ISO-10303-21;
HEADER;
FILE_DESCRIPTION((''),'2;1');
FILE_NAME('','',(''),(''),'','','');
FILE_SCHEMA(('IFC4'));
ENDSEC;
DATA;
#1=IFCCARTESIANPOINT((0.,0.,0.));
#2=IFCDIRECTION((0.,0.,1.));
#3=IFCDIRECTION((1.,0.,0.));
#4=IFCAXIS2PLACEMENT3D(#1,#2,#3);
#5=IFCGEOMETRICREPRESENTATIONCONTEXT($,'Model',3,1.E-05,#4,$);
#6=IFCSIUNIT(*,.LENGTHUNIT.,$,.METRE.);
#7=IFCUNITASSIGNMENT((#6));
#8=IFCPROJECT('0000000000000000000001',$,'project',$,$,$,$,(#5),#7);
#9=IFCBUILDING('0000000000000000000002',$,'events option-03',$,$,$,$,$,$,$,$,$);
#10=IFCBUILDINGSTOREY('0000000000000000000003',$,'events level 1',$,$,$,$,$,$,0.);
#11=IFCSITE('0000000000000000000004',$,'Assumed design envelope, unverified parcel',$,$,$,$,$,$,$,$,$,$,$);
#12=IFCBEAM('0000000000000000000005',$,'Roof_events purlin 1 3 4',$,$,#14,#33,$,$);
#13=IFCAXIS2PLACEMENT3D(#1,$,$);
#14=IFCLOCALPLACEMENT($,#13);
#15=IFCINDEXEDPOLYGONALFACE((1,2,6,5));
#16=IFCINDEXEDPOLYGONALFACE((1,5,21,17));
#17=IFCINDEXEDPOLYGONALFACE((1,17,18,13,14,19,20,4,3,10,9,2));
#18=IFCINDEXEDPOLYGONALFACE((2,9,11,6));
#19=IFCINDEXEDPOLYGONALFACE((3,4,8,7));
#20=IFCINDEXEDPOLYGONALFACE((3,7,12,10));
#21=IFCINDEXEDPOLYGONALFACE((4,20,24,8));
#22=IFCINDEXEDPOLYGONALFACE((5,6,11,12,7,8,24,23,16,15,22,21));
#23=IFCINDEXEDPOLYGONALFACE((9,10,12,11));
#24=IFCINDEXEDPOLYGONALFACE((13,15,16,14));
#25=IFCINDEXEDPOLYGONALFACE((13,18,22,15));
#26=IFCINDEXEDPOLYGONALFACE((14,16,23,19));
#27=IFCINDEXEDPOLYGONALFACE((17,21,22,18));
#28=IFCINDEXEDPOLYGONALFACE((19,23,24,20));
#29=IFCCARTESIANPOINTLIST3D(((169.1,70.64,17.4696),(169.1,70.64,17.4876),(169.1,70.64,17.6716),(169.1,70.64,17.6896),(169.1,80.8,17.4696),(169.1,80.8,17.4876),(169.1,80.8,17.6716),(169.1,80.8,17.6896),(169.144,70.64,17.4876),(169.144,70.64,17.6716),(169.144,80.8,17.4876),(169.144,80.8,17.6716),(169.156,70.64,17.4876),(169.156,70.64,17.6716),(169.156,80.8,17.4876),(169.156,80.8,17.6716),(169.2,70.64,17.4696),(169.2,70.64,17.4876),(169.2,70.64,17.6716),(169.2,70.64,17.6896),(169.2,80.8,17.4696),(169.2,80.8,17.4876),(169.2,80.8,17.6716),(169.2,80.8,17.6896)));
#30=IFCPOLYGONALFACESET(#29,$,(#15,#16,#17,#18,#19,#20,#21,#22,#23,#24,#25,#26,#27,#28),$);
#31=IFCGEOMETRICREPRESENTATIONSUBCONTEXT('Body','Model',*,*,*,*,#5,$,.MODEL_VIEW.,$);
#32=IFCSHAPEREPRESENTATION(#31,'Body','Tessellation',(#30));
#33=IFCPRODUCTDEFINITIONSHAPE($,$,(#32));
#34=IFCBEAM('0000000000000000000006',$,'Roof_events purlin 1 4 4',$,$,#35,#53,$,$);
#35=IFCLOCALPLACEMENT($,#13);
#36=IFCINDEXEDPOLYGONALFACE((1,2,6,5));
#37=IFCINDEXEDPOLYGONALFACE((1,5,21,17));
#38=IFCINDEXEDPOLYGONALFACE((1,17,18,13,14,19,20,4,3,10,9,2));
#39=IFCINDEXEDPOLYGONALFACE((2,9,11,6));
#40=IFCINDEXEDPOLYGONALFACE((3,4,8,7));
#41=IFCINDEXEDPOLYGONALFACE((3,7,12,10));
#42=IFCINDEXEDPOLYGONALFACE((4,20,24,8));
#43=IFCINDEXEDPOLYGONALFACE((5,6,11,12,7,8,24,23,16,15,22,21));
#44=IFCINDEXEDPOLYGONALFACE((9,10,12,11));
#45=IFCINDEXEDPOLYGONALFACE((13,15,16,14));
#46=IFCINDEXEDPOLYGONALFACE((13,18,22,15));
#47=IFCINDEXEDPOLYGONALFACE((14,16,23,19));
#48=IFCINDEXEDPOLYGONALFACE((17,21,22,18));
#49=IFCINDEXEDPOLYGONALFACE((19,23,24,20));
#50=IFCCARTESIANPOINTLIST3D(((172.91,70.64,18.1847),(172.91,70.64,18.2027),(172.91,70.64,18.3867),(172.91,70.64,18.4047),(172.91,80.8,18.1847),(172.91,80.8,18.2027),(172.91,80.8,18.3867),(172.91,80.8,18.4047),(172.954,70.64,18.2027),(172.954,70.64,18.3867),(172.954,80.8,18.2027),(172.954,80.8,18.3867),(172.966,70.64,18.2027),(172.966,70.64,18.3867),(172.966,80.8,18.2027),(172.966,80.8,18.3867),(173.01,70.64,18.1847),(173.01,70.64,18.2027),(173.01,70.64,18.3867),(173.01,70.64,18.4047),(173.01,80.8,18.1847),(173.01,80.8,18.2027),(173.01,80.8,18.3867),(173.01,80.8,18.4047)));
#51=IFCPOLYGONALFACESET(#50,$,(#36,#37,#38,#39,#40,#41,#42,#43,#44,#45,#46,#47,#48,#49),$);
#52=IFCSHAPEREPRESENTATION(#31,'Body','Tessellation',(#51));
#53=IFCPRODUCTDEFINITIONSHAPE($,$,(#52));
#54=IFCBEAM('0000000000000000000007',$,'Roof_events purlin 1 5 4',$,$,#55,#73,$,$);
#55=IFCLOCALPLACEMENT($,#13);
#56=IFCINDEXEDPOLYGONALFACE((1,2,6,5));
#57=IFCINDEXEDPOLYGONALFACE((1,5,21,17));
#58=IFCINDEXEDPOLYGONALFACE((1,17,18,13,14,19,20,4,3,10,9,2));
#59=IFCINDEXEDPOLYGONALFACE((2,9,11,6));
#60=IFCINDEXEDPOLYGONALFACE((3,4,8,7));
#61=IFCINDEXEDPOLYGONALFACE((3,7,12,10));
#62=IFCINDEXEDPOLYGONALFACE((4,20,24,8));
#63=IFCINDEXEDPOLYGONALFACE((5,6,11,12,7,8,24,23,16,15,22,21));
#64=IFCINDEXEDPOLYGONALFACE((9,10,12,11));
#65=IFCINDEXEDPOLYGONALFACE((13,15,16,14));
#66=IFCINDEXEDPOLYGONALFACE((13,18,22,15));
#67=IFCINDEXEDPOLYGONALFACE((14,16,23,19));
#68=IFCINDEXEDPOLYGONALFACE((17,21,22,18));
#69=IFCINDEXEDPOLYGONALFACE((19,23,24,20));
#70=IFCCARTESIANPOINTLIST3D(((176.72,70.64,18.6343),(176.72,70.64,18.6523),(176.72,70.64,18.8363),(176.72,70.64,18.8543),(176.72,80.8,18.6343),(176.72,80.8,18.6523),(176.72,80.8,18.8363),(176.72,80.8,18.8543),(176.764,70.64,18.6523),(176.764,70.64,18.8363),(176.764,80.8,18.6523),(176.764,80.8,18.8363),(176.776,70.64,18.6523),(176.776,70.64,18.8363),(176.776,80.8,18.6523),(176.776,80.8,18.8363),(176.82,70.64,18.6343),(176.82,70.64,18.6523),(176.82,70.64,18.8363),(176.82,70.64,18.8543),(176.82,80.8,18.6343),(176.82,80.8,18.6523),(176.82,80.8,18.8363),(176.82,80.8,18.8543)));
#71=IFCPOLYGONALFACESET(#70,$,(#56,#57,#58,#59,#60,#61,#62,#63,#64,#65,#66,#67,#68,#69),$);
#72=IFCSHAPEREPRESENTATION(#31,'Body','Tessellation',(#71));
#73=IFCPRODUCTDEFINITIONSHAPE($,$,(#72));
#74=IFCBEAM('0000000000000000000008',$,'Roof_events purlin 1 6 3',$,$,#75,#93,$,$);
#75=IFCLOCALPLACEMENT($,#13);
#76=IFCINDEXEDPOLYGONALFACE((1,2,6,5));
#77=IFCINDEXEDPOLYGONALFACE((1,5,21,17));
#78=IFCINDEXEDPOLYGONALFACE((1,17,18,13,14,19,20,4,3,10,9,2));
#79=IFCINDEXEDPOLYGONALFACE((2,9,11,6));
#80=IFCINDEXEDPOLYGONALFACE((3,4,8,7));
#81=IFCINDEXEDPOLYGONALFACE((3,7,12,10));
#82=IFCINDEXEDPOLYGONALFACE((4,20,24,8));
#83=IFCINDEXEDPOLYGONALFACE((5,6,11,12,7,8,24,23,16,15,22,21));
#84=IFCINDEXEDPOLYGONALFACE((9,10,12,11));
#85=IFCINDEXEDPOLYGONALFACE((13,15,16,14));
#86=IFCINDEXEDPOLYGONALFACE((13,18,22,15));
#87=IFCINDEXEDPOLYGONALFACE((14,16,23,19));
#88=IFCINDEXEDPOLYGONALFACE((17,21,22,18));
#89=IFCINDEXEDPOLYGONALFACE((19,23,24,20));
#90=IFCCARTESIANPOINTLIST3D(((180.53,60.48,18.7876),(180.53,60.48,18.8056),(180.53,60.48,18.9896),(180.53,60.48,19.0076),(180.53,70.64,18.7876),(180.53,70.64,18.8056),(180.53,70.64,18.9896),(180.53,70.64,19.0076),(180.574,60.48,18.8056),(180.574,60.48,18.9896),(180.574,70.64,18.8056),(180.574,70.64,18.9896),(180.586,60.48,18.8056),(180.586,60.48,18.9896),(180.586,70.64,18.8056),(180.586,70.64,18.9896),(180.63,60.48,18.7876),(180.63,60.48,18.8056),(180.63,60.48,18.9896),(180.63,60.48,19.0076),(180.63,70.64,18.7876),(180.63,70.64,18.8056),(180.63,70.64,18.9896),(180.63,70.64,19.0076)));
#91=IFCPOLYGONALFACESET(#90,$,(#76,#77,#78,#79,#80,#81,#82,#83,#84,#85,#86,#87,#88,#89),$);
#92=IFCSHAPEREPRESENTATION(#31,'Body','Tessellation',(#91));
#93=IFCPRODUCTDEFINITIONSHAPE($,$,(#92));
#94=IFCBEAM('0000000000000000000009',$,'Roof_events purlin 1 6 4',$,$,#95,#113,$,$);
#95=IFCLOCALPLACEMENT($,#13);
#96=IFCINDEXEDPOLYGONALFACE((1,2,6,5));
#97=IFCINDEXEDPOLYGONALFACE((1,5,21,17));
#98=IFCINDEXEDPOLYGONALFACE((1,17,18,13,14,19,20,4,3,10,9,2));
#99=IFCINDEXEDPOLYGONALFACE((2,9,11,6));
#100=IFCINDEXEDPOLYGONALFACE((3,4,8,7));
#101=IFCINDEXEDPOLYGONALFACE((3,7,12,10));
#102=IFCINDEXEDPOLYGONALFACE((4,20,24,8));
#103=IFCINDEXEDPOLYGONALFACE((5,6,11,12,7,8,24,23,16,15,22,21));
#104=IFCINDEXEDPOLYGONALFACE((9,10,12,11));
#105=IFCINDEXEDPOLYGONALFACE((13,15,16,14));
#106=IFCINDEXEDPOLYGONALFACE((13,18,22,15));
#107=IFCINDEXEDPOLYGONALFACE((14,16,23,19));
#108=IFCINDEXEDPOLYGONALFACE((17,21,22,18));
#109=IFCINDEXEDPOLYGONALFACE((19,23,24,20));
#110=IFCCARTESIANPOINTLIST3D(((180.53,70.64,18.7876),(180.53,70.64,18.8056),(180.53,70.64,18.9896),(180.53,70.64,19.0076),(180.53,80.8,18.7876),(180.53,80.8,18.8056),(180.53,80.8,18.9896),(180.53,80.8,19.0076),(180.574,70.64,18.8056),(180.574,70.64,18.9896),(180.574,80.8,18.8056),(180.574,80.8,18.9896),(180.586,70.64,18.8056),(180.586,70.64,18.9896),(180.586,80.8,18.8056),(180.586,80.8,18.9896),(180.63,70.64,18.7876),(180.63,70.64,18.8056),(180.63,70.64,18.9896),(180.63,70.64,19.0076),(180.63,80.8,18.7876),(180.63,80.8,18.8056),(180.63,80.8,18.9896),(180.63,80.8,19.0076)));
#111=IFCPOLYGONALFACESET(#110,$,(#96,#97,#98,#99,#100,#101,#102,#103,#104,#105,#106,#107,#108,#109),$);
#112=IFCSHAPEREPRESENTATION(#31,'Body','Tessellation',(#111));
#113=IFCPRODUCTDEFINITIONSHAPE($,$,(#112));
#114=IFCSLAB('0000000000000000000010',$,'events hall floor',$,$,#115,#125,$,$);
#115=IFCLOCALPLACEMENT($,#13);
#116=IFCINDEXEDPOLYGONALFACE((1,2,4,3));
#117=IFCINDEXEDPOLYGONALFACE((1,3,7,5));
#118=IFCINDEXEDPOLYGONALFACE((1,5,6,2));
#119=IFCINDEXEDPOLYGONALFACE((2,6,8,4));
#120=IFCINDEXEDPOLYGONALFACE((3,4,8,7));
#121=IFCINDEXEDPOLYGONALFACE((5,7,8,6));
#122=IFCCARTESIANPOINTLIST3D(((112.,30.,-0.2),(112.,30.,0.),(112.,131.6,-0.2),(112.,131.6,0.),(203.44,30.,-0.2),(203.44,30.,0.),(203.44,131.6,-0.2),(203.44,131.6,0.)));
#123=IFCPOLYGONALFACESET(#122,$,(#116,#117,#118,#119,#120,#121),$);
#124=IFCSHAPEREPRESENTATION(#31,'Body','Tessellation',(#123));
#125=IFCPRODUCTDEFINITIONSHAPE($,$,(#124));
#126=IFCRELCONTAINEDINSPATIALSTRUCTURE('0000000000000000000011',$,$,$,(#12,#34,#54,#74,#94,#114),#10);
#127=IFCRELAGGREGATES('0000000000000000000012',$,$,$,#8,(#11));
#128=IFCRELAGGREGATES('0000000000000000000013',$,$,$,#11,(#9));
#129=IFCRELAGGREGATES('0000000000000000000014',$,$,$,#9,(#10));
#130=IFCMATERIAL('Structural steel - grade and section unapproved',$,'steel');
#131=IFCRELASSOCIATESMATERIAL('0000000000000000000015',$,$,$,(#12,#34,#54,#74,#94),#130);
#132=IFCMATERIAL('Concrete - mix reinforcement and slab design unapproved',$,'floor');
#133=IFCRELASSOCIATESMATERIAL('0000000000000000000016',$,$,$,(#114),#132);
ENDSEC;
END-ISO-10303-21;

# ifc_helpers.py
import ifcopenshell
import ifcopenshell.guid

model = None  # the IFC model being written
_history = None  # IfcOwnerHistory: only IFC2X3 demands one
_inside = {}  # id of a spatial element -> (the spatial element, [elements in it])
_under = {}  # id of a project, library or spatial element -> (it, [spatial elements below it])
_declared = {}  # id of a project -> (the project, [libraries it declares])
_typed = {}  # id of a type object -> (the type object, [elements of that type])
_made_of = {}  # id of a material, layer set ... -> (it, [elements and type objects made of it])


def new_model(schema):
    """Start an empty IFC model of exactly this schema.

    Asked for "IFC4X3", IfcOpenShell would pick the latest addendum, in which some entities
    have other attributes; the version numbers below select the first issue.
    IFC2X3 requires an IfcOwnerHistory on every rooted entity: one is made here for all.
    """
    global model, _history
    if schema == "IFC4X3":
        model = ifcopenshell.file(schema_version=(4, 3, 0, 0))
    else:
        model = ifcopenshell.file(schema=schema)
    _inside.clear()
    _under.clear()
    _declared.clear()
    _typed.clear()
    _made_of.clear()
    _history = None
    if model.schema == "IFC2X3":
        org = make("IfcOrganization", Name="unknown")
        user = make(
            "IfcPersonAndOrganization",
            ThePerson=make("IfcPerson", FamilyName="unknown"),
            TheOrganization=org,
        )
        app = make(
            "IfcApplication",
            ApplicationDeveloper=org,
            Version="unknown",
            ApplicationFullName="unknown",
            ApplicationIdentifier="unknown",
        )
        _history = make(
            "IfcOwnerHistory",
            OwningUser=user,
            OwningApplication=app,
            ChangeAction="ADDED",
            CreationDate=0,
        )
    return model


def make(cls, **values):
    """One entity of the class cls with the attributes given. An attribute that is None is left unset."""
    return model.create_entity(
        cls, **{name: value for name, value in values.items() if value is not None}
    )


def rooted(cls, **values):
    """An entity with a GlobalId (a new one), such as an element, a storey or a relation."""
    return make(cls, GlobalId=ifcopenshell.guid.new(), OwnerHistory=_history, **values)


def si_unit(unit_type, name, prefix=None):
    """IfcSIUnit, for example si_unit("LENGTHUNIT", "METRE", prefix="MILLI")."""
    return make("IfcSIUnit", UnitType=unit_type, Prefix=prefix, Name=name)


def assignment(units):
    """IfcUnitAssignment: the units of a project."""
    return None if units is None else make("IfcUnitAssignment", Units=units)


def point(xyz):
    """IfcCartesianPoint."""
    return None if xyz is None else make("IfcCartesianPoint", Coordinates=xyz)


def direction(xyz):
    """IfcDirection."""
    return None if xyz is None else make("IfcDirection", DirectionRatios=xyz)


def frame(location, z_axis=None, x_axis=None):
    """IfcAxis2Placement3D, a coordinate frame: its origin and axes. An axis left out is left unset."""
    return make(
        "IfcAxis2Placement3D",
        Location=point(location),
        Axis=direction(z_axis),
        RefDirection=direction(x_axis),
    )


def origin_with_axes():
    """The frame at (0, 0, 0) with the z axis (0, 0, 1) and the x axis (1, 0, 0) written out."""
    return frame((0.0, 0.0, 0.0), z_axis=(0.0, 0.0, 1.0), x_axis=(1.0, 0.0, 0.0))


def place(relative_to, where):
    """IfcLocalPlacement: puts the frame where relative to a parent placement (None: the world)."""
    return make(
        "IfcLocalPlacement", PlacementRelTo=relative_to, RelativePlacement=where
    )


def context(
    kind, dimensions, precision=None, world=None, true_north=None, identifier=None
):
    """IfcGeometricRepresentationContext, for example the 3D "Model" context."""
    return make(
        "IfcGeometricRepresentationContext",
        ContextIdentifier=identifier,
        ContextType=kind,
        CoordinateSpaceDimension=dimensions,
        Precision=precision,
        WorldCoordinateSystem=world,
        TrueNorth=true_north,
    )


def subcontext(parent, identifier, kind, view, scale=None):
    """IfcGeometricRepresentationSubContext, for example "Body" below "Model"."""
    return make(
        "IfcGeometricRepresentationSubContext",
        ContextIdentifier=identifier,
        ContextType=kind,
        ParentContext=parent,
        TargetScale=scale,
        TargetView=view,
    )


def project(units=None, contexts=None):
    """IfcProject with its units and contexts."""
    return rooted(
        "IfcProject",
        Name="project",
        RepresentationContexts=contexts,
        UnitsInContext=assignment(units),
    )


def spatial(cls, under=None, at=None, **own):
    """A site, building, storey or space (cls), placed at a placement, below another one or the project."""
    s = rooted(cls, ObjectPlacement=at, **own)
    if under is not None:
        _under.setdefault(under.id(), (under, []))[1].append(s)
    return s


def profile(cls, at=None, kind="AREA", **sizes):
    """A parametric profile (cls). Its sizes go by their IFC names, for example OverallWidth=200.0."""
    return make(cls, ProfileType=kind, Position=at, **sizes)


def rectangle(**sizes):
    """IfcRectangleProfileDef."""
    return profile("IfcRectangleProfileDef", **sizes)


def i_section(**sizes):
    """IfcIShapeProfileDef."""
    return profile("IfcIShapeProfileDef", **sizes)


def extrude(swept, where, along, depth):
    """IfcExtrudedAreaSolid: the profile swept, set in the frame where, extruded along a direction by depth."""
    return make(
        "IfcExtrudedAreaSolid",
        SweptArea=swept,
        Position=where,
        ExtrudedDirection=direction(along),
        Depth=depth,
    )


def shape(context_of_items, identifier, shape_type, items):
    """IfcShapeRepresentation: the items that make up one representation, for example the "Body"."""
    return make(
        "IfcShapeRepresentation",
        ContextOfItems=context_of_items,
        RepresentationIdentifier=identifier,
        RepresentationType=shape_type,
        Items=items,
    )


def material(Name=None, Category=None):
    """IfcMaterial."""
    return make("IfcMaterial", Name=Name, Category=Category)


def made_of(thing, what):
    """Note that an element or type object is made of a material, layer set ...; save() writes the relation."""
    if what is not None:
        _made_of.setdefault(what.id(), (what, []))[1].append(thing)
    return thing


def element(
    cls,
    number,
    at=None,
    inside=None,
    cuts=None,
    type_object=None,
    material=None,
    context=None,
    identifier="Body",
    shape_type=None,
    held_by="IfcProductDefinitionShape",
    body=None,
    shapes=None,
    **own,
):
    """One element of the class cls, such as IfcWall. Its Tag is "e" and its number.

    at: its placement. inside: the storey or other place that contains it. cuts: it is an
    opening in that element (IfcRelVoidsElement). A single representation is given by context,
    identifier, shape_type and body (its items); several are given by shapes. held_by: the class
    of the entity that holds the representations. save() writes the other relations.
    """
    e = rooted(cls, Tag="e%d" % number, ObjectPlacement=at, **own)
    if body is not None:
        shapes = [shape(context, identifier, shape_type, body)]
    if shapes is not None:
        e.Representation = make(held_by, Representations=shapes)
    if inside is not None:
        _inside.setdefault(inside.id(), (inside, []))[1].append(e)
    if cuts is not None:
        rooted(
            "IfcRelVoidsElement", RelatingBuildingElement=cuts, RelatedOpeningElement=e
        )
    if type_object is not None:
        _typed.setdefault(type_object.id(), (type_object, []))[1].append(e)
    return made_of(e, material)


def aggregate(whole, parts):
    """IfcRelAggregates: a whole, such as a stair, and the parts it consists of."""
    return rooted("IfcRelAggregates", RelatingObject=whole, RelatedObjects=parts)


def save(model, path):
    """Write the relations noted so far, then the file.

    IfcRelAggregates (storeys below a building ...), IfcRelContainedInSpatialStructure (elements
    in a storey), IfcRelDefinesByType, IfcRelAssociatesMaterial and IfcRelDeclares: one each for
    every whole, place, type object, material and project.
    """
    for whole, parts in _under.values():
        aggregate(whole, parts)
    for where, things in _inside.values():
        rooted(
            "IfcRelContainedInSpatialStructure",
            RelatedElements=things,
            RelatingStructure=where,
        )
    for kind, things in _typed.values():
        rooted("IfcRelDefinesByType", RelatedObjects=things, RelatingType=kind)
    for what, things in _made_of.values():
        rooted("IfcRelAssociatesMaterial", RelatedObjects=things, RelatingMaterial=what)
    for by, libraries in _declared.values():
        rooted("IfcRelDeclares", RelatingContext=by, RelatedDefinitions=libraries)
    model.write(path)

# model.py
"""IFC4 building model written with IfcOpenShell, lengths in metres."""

from ifc_helpers import new_model, si_unit, frame, origin_with_axes, place, context, subcontext, project, spatial, rectangle, i_section, extrude, material, element, save


model = new_model("IFC4")

# Units and contexts
model_context = context("Model", 3, precision=1e-05, world=origin_with_axes())
body_context = subcontext(model_context, "Body", "Model", "MODEL_VIEW")
ifc_project = project(units=[si_unit("LENGTHUNIT", "METRE")], contexts=[model_context])

# Site, building, storey
site = spatial("IfcSite", under=ifc_project, Name="Assumed design envelope, unverified parcel")
building = spatial("IfcBuilding", under=site, Name="events option-03")
storey = spatial("IfcBuildingStorey", under=building, Name="events level 1", Elevation=0.0)

# Shared definitions
ifc_material_1 = material(Name="Structural steel - grade and section unapproved", Category="steel")

# Beams
for number, where, z_axis, x_axis, name in (
    (1, (169.15, 70.64, 17.5796), (0.0, 1.0, 0.0), (-1.0, 0.0, 0.0), "Roof_events purlin 1 3 4"),
    (2, (172.96, 70.64, 18.2947), (0.0, 1.0, 0.0), (-1.0, 0.0, 0.0), "Roof_events purlin 1 4 4"),
    (3, (176.77, 70.64, 18.7443), (0.0, 1.0, 0.0), (-1.0, 0.0, 0.0), "Roof_events purlin 1 5 4"),
):
    element("IfcBeam", number, at=place(None, frame(where, z_axis=z_axis, x_axis=x_axis)), inside=storey, material=ifc_material_1, Name=name, context=body_context, shape_type="SweptSolid", body=[
        extrude(i_section(OverallWidth=0.1, OverallDepth=0.22, WebThickness=0.012, FlangeThickness=0.018, FilletRadius=0.0), origin_with_axes(), (0.0, 0.0, 1.0), 10.16),
    ])
beam_1_placement = place(None, frame((180.58, 60.48, 18.8976), z_axis=(0.0, 1.0, 0.0), x_axis=(-1.0, 0.0, 0.0)))
element("IfcBeam", 4, at=beam_1_placement, inside=storey, material=ifc_material_1, Name="Roof_events purlin 1 6 3", context=body_context, shape_type="SweptSolid", body=[
    extrude(i_section(OverallWidth=0.1, OverallDepth=0.22, WebThickness=0.012, FlangeThickness=0.018, FilletRadius=0.0), origin_with_axes(), (0.0, 0.0, 1.0), 10.16),
])
beam_2_placement = place(None, frame((180.58, 70.64, 18.8976), z_axis=(0.0, 1.0, 0.0), x_axis=(-1.0, 0.0, 0.0)))
element("IfcBeam", 5, at=beam_2_placement, inside=storey, material=ifc_material_1, Name="Roof_events purlin 1 6 4", context=body_context, shape_type="SweptSolid", body=[
    extrude(i_section(OverallWidth=0.1, OverallDepth=0.22, WebThickness=0.012, FlangeThickness=0.018, FilletRadius=0.0), origin_with_axes(), (0.0, 0.0, 1.0), 10.16),
])

# Slab
ifc_material_2 = material(Name="Concrete - mix reinforcement and slab design unapproved", Category="floor")
slab_placement = place(None, frame((157.72, 80.8, -0.2), z_axis=(0.0, 0.0, 1.0), x_axis=(1.0, 0.0, 0.0)))
element("IfcSlab", 6, at=slab_placement, inside=storey, material=ifc_material_2, Name="events hall floor", context=body_context, shape_type="SweptSolid", body=[
    extrude(rectangle(XDim=91.44, YDim=101.6), origin_with_axes(), (0.0, 0.0, 1.0), 0.2),
])

save(model, "model.ifc")
